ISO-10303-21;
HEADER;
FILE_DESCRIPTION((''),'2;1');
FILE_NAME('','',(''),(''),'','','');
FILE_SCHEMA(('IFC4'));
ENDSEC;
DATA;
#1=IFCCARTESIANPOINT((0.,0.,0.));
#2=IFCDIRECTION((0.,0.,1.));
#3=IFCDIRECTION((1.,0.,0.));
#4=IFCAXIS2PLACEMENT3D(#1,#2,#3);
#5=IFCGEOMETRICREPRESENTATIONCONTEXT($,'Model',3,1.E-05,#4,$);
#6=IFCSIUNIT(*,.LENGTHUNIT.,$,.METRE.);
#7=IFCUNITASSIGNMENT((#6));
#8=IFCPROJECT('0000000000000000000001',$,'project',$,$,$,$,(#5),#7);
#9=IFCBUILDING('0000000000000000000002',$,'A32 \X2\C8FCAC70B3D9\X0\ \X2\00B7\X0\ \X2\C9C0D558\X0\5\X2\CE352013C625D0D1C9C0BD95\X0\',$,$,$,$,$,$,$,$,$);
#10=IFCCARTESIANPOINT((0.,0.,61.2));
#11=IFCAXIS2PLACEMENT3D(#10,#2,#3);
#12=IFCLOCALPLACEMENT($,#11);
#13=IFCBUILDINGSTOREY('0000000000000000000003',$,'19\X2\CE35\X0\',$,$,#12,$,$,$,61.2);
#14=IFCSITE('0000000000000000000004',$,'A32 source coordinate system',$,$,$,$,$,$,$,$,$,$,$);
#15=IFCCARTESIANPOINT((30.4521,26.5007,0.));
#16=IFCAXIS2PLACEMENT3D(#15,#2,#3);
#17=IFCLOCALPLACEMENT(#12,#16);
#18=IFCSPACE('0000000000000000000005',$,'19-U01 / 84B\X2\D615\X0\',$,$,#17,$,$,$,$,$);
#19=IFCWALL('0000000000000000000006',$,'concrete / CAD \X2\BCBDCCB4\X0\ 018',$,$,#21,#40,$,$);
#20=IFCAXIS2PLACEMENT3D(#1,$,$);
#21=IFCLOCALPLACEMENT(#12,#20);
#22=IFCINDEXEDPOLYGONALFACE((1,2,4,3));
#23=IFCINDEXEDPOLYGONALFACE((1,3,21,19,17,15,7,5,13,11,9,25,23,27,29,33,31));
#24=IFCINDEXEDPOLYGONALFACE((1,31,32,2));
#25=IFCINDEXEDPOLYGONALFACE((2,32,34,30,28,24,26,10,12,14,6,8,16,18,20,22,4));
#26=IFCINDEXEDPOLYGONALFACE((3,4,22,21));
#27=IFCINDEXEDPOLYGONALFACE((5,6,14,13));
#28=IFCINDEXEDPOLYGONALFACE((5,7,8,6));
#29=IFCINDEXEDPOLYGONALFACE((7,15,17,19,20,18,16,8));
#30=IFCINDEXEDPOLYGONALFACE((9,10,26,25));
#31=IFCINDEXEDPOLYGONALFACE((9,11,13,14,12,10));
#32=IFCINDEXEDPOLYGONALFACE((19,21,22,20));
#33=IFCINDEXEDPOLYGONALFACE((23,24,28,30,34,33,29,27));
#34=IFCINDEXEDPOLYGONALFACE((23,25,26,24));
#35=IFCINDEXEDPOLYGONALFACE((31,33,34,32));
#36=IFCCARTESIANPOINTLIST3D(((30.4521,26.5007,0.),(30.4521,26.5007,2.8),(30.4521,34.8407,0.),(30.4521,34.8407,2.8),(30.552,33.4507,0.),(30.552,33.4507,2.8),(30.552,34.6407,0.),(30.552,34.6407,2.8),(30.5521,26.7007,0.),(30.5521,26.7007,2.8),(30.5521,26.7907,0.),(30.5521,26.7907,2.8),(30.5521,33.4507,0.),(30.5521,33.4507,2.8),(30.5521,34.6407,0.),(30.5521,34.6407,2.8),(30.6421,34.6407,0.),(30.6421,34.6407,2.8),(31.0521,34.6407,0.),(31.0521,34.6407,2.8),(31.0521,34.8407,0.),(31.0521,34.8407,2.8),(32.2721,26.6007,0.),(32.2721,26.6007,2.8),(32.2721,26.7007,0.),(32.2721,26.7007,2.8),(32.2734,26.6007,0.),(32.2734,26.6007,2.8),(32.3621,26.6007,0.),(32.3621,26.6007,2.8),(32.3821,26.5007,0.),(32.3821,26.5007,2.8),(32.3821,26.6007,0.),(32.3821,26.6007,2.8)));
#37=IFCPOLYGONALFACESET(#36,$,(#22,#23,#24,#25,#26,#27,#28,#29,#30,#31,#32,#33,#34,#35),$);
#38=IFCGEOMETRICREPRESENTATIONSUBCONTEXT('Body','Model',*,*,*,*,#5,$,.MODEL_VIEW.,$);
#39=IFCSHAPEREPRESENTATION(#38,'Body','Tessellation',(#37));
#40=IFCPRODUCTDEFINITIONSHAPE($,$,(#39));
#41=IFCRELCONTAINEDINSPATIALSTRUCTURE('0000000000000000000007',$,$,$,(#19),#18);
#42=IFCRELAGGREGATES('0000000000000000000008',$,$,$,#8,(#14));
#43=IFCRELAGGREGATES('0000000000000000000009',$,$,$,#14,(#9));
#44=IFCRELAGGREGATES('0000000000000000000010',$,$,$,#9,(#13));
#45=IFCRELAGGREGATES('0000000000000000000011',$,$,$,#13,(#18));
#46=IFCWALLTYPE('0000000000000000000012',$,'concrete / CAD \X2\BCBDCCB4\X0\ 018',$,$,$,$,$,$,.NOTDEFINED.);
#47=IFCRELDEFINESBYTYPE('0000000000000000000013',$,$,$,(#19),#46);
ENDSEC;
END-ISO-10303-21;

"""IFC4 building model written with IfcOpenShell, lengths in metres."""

from ifc_helpers import new_model, si_unit, frame, origin, origin_with_axes, place, context, subcontext, project, spatial, polyline, outline, extrude, source, transform, mapped, type_object, type_shapes, element, save


model = new_model("IFC4")

# Units and contexts
model_context = context("Model", 3, precision=1e-05, world=origin_with_axes())
body_context = subcontext(model_context, "Body", "Model", "MODEL_VIEW")
ifc_project = project(units=[si_unit("LENGTHUNIT", "METRE")], contexts=[model_context])

# Site, building, storey, space
site = spatial("IfcSite", under=ifc_project, Name="A32 source coordinate system")
building = spatial("IfcBuilding", under=site, Name="A32 주거동 · 지하5층–옥탑지붕")
storey_placement = place(None, frame((0.0, 0.0, 61.2), z_axis=(0.0, 0.0, 1.0), x_axis=(1.0, 0.0, 0.0)))
storey = spatial("IfcBuildingStorey", under=building, at=storey_placement, Name="19층", Elevation=61.2)
space_1_placement = place(storey_placement, frame((30.4521, 26.5007, 0.0), z_axis=(0.0, 0.0, 1.0), x_axis=(1.0, 0.0, 0.0)))
space_1 = spatial("IfcSpace", under=storey, at=space_1_placement, Name="19-U01 / 84B형")

# Wall
wall_type_1 = type_object("IfcWallType", Name="concrete / CAD 벽체 018", PredefinedType="NOTDEFINED")
shared_shape_1 = source(origin(), body_context, "Body", "SweptSolid", [
    extrude(outline(polyline([(0.6, 8.34), (0.6, 8.14), (0.19, 8.14), (0.1, 8.14), (0.0999, 8.14), (0.0999, 6.95), (0.1, 6.95), (0.1, 0.29), (0.1, 0.2), (1.82, 0.2), (1.82, 0.1), (1.8213, 0.1), (1.91, 0.1), (1.93, 0.1), (1.93, 0.0), (0.0, 0.0), (0.0, 8.34), (-0.35, 8.34), (-0.35, 8.34), (0.6, 8.34)])), origin(), (0.0, 0.0, 1.0), 2.8),
])
type_shapes(wall_type_1, [shared_shape_1])
wall_1_placement = place(space_1_placement, origin_with_axes())
element("IfcWall", 1, at=wall_1_placement, inside=space_1, type_object=wall_type_1, Name="concrete / CAD 벽체 018", context=body_context, shape_type="MappedRepresentation", body=[
    mapped(shared_shape_1, transform((0.0, 0.0, 0.0), scale=1.0)),
])

save(model, "model.ifc")
